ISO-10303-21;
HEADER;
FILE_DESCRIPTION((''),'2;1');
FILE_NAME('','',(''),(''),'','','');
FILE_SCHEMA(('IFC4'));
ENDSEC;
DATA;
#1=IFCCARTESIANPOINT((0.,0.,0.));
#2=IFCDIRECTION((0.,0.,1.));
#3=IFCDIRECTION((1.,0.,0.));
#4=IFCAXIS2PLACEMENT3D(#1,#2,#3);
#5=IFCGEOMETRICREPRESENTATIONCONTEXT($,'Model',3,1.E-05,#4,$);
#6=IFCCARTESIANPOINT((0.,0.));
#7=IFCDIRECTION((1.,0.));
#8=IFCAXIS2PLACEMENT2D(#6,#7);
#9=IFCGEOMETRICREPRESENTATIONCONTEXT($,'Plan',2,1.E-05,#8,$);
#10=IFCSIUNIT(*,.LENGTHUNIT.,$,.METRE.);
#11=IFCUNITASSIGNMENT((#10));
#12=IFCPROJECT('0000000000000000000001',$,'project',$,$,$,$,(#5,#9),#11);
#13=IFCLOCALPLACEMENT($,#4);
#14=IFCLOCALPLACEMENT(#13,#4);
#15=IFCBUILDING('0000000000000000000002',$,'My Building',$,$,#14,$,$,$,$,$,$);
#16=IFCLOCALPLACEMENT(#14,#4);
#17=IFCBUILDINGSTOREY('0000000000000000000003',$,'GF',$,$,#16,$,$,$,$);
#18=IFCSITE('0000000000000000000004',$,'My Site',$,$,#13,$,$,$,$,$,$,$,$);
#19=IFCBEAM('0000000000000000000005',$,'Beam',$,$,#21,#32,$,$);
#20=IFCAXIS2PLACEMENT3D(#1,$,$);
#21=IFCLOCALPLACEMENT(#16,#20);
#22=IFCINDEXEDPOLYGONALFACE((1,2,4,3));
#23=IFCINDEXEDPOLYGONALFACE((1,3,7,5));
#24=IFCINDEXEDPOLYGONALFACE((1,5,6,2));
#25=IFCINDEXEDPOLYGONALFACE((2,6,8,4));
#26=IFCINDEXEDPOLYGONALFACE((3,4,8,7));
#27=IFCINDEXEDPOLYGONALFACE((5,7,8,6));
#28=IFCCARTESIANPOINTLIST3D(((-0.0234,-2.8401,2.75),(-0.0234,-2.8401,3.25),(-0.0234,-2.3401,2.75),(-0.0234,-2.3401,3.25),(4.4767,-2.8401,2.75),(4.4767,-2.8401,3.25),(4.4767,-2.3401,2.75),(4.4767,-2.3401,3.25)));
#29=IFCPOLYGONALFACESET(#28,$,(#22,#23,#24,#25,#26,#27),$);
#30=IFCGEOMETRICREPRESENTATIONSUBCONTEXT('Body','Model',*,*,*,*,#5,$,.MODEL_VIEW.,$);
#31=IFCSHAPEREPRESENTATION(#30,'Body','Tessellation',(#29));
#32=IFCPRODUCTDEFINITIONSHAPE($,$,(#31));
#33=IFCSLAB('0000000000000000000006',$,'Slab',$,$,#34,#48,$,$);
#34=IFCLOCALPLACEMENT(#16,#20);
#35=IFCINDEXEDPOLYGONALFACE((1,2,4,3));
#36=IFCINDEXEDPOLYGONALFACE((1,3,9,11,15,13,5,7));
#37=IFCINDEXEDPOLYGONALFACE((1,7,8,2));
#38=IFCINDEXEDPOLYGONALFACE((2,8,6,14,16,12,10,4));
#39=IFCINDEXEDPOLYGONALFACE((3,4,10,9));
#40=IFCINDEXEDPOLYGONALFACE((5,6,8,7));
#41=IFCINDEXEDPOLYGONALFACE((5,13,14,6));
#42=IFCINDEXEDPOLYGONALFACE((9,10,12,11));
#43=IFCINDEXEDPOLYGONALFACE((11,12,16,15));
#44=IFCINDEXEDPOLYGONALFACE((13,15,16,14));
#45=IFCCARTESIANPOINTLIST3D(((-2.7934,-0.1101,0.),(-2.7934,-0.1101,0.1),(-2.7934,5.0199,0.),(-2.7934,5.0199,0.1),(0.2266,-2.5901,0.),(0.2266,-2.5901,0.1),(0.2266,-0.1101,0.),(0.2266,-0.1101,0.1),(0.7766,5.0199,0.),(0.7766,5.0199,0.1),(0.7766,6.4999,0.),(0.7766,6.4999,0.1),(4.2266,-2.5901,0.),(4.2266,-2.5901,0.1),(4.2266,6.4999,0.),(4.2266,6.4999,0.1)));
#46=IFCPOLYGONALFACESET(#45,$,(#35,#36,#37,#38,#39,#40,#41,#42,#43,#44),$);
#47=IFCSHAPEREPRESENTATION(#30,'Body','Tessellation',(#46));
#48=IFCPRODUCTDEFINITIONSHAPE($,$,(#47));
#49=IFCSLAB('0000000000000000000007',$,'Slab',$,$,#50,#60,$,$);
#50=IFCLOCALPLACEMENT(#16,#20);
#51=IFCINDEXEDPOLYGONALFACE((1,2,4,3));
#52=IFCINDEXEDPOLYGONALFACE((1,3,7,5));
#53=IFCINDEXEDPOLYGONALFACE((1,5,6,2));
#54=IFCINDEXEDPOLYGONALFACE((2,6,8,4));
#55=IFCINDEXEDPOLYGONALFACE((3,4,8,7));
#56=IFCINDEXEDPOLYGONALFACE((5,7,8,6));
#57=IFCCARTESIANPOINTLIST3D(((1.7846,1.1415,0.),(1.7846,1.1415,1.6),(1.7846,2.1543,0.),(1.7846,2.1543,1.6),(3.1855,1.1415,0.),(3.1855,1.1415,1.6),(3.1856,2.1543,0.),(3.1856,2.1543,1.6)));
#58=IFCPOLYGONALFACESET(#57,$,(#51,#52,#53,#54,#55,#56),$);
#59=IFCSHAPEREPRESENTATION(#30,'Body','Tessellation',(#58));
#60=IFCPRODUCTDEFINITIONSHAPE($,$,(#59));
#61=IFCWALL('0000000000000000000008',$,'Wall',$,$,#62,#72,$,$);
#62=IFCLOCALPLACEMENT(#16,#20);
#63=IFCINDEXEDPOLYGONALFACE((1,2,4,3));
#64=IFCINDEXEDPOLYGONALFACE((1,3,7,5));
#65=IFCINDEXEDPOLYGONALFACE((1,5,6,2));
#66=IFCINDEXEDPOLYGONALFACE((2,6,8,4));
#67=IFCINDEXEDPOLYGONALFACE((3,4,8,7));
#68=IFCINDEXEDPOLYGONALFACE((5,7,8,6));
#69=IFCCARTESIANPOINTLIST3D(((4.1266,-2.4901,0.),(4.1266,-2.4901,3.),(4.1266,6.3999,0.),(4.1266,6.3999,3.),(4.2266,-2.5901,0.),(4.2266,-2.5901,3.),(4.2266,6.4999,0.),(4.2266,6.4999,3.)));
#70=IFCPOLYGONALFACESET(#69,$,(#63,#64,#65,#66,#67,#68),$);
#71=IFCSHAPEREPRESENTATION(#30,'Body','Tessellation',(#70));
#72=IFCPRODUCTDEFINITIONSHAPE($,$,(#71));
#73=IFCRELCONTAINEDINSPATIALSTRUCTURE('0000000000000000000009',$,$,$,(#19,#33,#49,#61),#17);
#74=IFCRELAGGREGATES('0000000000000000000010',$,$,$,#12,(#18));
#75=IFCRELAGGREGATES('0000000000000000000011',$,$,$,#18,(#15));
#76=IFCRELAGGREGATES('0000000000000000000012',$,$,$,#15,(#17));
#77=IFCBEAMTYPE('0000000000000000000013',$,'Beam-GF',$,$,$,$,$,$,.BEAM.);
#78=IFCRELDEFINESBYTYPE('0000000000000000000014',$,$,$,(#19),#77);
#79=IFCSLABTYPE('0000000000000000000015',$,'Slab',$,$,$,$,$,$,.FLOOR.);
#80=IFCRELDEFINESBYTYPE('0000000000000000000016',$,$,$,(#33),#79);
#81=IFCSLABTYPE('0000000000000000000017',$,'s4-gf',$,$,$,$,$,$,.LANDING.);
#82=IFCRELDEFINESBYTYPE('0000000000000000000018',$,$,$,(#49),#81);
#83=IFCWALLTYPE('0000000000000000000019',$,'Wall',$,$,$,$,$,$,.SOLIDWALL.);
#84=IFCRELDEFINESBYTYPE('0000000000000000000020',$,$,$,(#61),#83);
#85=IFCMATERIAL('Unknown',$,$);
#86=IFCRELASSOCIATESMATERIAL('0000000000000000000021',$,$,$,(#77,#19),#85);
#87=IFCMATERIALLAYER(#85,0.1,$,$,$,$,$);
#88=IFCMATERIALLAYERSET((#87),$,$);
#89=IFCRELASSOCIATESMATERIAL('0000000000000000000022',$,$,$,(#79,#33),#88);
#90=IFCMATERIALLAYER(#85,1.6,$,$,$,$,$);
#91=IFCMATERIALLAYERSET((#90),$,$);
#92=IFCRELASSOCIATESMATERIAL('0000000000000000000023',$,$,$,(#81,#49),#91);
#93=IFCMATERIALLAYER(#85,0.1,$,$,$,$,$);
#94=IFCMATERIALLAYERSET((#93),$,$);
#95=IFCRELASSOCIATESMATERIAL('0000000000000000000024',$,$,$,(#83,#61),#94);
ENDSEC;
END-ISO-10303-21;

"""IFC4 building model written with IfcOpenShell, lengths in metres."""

from ifc_helpers import new_model, si_unit, frame, origin_with_axes, origin_2d_with_axis, place, context, subcontext, project, spatial, line, indexed_curve, rectangle, outline, extrude, material, layer, layer_set, layer_usage, material_profile, profile_set, profile_usage, type_object, element, save


model = new_model("IFC4")

# Units and contexts
model_context = context("Model", 3, precision=1e-05, world=origin_with_axes())
plan_context = context("Plan", 2, precision=1e-05, world=origin_2d_with_axis())
body_context_1 = subcontext(model_context, "Body", "Model", "MODEL_VIEW")
ifc_project = project(units=[si_unit("LENGTHUNIT", "METRE")], contexts=[model_context, plan_context])

# Site, building, storey
site_placement = place(None, origin_with_axes())
site = spatial("IfcSite", under=ifc_project, at=site_placement, Name="My Site")
building_placement = place(site_placement, origin_with_axes())
building = spatial("IfcBuilding", under=site, at=building_placement, Name="My Building")
storey_placement = place(building_placement, origin_with_axes())
storey = spatial("IfcBuildingStorey", under=building, at=storey_placement, Name="GF")

# Shared definitions
ifc_material = material(Name="Unknown")

# Beam
ifc_material_profile_1 = material_profile(ifc_material, rectangle(XDim=0.5, YDim=0.5))
ifc_profile_set_1 = profile_set([ifc_material_profile_1])
beam_type = type_object("IfcBeamType", Name="Beam-GF", PredefinedType="BEAM", material=ifc_profile_set_1)
ifc_profile_usage_1 = profile_usage(ifc_profile_set_1, cardinal=5)
beam_1_placement = place(storey_placement, frame((-0.0234, -2.5901, 3.0), z_axis=(1.0, 0.0, 0.0), x_axis=(0.0, 1.0, 0.0)))
element("IfcBeam", 1, at=beam_1_placement, inside=storey, type_object=beam_type, material=ifc_profile_usage_1, Name="Beam", context=body_context_1, shape_type="SweptSolid", body=[
    extrude(rectangle(XDim=0.5, YDim=0.5), origin_with_axes(), (0.0, 0.0, 1.0), 4.5001),
])

# Slabs
ifc_layer_1 = layer(ifc_material, 0.1)
ifc_layer_set_1 = layer_set([ifc_layer_1])
ifc_layer_usage_1 = layer_usage(ifc_layer_set_1, "AXIS3", "POSITIVE", -0.1)
slab_type_1 = type_object("IfcSlabType", Name="Slab", PredefinedType="FLOOR", material=ifc_layer_set_1)
slab_1_placement = place(storey_placement, frame((4.2266, -2.5901, 0.1), z_axis=(0.0, 0.0, 1.0), x_axis=(1.0, 0.0, 0.0)))
element("IfcSlab", 2, at=slab_1_placement, inside=storey, type_object=slab_type_1, material=ifc_layer_usage_1, Name="Slab", context=body_context_1, shape_type="SweptSolid", body=[
    extrude(outline(indexed_curve([(0.0, 0.0), (-4.0, 0.0), (-4.0, 2.48), (-7.02, 2.48), (-7.02, 7.61), (-3.45, 7.61), (-3.45, 9.09), (0.0, 9.09), (0.0, 0.0)])), frame((0.0, 0.0, -0.1), z_axis=(0.0, 0.0, 1.0), x_axis=(1.0, 0.0, 0.0)), (0.0, 0.0, 1.0), 0.1),
])
ifc_layer_2 = layer(ifc_material, 1.6)
ifc_layer_set_2 = layer_set([ifc_layer_2])
ifc_layer_usage_2 = layer_usage(ifc_layer_set_2, "AXIS3", "POSITIVE", -1.8)
slab_type_2 = type_object("IfcSlabType", Name="s4-gf", PredefinedType="LANDING", material=ifc_layer_set_2)
slab_2_placement = place(storey_placement, frame((3.1855, 1.1415, 1.8), z_axis=(0.0, 0.0, 1.0), x_axis=(1.0, 0.0, 0.0)))
element("IfcSlab", 3, at=slab_2_placement, inside=storey, type_object=slab_type_2, material=ifc_layer_usage_2, Name="Slab", context=body_context_1, shape_type="SweptSolid", body=[
    extrude(outline(indexed_curve([(0.0001, 1.0128), (-1.401, 1.0128), (-1.4009, 0.0001), (0.0, 0.0), (0.0001, 1.0128)])), frame((0.0, 0.0, -1.8), z_axis=(0.0, 0.0, 1.0), x_axis=(1.0, 0.0, 0.0)), (0.0, 0.0, 1.0), 1.6),
])

# Shared definitions
ifc_layer_3 = layer(ifc_material, 0.1)
ifc_layer_set_3 = layer_set([ifc_layer_3])
wall_type = type_object("IfcWallType", Name="Wall", PredefinedType="SOLIDWALL", material=ifc_layer_set_3)

# Wall
ifc_layer_usage_3 = layer_usage(ifc_layer_set_3, "AXIS2", "POSITIVE", 0.0)
wall_1_placement = place(storey_placement, frame((4.2266, -2.5901, 0.0), z_axis=(0.0, 0.0, 1.0), x_axis=(0.0, 1.0, 0.0)))
element("IfcWall", 4, at=wall_1_placement, inside=storey, type_object=wall_type, material=ifc_layer_usage_3, Name="Wall", context=body_context_1, shape_type="SweptSolid", body=[
    extrude(outline(indexed_curve([(0.0, 0.0), (0.1, 0.1), (8.99, 0.1), (9.09, 0.0)], segments=[line(1, 2, 3, 4, 1)])), origin_with_axes(), (0.0, 0.0, 1.0), 3.0),
])

save(model, "model.ifc")
